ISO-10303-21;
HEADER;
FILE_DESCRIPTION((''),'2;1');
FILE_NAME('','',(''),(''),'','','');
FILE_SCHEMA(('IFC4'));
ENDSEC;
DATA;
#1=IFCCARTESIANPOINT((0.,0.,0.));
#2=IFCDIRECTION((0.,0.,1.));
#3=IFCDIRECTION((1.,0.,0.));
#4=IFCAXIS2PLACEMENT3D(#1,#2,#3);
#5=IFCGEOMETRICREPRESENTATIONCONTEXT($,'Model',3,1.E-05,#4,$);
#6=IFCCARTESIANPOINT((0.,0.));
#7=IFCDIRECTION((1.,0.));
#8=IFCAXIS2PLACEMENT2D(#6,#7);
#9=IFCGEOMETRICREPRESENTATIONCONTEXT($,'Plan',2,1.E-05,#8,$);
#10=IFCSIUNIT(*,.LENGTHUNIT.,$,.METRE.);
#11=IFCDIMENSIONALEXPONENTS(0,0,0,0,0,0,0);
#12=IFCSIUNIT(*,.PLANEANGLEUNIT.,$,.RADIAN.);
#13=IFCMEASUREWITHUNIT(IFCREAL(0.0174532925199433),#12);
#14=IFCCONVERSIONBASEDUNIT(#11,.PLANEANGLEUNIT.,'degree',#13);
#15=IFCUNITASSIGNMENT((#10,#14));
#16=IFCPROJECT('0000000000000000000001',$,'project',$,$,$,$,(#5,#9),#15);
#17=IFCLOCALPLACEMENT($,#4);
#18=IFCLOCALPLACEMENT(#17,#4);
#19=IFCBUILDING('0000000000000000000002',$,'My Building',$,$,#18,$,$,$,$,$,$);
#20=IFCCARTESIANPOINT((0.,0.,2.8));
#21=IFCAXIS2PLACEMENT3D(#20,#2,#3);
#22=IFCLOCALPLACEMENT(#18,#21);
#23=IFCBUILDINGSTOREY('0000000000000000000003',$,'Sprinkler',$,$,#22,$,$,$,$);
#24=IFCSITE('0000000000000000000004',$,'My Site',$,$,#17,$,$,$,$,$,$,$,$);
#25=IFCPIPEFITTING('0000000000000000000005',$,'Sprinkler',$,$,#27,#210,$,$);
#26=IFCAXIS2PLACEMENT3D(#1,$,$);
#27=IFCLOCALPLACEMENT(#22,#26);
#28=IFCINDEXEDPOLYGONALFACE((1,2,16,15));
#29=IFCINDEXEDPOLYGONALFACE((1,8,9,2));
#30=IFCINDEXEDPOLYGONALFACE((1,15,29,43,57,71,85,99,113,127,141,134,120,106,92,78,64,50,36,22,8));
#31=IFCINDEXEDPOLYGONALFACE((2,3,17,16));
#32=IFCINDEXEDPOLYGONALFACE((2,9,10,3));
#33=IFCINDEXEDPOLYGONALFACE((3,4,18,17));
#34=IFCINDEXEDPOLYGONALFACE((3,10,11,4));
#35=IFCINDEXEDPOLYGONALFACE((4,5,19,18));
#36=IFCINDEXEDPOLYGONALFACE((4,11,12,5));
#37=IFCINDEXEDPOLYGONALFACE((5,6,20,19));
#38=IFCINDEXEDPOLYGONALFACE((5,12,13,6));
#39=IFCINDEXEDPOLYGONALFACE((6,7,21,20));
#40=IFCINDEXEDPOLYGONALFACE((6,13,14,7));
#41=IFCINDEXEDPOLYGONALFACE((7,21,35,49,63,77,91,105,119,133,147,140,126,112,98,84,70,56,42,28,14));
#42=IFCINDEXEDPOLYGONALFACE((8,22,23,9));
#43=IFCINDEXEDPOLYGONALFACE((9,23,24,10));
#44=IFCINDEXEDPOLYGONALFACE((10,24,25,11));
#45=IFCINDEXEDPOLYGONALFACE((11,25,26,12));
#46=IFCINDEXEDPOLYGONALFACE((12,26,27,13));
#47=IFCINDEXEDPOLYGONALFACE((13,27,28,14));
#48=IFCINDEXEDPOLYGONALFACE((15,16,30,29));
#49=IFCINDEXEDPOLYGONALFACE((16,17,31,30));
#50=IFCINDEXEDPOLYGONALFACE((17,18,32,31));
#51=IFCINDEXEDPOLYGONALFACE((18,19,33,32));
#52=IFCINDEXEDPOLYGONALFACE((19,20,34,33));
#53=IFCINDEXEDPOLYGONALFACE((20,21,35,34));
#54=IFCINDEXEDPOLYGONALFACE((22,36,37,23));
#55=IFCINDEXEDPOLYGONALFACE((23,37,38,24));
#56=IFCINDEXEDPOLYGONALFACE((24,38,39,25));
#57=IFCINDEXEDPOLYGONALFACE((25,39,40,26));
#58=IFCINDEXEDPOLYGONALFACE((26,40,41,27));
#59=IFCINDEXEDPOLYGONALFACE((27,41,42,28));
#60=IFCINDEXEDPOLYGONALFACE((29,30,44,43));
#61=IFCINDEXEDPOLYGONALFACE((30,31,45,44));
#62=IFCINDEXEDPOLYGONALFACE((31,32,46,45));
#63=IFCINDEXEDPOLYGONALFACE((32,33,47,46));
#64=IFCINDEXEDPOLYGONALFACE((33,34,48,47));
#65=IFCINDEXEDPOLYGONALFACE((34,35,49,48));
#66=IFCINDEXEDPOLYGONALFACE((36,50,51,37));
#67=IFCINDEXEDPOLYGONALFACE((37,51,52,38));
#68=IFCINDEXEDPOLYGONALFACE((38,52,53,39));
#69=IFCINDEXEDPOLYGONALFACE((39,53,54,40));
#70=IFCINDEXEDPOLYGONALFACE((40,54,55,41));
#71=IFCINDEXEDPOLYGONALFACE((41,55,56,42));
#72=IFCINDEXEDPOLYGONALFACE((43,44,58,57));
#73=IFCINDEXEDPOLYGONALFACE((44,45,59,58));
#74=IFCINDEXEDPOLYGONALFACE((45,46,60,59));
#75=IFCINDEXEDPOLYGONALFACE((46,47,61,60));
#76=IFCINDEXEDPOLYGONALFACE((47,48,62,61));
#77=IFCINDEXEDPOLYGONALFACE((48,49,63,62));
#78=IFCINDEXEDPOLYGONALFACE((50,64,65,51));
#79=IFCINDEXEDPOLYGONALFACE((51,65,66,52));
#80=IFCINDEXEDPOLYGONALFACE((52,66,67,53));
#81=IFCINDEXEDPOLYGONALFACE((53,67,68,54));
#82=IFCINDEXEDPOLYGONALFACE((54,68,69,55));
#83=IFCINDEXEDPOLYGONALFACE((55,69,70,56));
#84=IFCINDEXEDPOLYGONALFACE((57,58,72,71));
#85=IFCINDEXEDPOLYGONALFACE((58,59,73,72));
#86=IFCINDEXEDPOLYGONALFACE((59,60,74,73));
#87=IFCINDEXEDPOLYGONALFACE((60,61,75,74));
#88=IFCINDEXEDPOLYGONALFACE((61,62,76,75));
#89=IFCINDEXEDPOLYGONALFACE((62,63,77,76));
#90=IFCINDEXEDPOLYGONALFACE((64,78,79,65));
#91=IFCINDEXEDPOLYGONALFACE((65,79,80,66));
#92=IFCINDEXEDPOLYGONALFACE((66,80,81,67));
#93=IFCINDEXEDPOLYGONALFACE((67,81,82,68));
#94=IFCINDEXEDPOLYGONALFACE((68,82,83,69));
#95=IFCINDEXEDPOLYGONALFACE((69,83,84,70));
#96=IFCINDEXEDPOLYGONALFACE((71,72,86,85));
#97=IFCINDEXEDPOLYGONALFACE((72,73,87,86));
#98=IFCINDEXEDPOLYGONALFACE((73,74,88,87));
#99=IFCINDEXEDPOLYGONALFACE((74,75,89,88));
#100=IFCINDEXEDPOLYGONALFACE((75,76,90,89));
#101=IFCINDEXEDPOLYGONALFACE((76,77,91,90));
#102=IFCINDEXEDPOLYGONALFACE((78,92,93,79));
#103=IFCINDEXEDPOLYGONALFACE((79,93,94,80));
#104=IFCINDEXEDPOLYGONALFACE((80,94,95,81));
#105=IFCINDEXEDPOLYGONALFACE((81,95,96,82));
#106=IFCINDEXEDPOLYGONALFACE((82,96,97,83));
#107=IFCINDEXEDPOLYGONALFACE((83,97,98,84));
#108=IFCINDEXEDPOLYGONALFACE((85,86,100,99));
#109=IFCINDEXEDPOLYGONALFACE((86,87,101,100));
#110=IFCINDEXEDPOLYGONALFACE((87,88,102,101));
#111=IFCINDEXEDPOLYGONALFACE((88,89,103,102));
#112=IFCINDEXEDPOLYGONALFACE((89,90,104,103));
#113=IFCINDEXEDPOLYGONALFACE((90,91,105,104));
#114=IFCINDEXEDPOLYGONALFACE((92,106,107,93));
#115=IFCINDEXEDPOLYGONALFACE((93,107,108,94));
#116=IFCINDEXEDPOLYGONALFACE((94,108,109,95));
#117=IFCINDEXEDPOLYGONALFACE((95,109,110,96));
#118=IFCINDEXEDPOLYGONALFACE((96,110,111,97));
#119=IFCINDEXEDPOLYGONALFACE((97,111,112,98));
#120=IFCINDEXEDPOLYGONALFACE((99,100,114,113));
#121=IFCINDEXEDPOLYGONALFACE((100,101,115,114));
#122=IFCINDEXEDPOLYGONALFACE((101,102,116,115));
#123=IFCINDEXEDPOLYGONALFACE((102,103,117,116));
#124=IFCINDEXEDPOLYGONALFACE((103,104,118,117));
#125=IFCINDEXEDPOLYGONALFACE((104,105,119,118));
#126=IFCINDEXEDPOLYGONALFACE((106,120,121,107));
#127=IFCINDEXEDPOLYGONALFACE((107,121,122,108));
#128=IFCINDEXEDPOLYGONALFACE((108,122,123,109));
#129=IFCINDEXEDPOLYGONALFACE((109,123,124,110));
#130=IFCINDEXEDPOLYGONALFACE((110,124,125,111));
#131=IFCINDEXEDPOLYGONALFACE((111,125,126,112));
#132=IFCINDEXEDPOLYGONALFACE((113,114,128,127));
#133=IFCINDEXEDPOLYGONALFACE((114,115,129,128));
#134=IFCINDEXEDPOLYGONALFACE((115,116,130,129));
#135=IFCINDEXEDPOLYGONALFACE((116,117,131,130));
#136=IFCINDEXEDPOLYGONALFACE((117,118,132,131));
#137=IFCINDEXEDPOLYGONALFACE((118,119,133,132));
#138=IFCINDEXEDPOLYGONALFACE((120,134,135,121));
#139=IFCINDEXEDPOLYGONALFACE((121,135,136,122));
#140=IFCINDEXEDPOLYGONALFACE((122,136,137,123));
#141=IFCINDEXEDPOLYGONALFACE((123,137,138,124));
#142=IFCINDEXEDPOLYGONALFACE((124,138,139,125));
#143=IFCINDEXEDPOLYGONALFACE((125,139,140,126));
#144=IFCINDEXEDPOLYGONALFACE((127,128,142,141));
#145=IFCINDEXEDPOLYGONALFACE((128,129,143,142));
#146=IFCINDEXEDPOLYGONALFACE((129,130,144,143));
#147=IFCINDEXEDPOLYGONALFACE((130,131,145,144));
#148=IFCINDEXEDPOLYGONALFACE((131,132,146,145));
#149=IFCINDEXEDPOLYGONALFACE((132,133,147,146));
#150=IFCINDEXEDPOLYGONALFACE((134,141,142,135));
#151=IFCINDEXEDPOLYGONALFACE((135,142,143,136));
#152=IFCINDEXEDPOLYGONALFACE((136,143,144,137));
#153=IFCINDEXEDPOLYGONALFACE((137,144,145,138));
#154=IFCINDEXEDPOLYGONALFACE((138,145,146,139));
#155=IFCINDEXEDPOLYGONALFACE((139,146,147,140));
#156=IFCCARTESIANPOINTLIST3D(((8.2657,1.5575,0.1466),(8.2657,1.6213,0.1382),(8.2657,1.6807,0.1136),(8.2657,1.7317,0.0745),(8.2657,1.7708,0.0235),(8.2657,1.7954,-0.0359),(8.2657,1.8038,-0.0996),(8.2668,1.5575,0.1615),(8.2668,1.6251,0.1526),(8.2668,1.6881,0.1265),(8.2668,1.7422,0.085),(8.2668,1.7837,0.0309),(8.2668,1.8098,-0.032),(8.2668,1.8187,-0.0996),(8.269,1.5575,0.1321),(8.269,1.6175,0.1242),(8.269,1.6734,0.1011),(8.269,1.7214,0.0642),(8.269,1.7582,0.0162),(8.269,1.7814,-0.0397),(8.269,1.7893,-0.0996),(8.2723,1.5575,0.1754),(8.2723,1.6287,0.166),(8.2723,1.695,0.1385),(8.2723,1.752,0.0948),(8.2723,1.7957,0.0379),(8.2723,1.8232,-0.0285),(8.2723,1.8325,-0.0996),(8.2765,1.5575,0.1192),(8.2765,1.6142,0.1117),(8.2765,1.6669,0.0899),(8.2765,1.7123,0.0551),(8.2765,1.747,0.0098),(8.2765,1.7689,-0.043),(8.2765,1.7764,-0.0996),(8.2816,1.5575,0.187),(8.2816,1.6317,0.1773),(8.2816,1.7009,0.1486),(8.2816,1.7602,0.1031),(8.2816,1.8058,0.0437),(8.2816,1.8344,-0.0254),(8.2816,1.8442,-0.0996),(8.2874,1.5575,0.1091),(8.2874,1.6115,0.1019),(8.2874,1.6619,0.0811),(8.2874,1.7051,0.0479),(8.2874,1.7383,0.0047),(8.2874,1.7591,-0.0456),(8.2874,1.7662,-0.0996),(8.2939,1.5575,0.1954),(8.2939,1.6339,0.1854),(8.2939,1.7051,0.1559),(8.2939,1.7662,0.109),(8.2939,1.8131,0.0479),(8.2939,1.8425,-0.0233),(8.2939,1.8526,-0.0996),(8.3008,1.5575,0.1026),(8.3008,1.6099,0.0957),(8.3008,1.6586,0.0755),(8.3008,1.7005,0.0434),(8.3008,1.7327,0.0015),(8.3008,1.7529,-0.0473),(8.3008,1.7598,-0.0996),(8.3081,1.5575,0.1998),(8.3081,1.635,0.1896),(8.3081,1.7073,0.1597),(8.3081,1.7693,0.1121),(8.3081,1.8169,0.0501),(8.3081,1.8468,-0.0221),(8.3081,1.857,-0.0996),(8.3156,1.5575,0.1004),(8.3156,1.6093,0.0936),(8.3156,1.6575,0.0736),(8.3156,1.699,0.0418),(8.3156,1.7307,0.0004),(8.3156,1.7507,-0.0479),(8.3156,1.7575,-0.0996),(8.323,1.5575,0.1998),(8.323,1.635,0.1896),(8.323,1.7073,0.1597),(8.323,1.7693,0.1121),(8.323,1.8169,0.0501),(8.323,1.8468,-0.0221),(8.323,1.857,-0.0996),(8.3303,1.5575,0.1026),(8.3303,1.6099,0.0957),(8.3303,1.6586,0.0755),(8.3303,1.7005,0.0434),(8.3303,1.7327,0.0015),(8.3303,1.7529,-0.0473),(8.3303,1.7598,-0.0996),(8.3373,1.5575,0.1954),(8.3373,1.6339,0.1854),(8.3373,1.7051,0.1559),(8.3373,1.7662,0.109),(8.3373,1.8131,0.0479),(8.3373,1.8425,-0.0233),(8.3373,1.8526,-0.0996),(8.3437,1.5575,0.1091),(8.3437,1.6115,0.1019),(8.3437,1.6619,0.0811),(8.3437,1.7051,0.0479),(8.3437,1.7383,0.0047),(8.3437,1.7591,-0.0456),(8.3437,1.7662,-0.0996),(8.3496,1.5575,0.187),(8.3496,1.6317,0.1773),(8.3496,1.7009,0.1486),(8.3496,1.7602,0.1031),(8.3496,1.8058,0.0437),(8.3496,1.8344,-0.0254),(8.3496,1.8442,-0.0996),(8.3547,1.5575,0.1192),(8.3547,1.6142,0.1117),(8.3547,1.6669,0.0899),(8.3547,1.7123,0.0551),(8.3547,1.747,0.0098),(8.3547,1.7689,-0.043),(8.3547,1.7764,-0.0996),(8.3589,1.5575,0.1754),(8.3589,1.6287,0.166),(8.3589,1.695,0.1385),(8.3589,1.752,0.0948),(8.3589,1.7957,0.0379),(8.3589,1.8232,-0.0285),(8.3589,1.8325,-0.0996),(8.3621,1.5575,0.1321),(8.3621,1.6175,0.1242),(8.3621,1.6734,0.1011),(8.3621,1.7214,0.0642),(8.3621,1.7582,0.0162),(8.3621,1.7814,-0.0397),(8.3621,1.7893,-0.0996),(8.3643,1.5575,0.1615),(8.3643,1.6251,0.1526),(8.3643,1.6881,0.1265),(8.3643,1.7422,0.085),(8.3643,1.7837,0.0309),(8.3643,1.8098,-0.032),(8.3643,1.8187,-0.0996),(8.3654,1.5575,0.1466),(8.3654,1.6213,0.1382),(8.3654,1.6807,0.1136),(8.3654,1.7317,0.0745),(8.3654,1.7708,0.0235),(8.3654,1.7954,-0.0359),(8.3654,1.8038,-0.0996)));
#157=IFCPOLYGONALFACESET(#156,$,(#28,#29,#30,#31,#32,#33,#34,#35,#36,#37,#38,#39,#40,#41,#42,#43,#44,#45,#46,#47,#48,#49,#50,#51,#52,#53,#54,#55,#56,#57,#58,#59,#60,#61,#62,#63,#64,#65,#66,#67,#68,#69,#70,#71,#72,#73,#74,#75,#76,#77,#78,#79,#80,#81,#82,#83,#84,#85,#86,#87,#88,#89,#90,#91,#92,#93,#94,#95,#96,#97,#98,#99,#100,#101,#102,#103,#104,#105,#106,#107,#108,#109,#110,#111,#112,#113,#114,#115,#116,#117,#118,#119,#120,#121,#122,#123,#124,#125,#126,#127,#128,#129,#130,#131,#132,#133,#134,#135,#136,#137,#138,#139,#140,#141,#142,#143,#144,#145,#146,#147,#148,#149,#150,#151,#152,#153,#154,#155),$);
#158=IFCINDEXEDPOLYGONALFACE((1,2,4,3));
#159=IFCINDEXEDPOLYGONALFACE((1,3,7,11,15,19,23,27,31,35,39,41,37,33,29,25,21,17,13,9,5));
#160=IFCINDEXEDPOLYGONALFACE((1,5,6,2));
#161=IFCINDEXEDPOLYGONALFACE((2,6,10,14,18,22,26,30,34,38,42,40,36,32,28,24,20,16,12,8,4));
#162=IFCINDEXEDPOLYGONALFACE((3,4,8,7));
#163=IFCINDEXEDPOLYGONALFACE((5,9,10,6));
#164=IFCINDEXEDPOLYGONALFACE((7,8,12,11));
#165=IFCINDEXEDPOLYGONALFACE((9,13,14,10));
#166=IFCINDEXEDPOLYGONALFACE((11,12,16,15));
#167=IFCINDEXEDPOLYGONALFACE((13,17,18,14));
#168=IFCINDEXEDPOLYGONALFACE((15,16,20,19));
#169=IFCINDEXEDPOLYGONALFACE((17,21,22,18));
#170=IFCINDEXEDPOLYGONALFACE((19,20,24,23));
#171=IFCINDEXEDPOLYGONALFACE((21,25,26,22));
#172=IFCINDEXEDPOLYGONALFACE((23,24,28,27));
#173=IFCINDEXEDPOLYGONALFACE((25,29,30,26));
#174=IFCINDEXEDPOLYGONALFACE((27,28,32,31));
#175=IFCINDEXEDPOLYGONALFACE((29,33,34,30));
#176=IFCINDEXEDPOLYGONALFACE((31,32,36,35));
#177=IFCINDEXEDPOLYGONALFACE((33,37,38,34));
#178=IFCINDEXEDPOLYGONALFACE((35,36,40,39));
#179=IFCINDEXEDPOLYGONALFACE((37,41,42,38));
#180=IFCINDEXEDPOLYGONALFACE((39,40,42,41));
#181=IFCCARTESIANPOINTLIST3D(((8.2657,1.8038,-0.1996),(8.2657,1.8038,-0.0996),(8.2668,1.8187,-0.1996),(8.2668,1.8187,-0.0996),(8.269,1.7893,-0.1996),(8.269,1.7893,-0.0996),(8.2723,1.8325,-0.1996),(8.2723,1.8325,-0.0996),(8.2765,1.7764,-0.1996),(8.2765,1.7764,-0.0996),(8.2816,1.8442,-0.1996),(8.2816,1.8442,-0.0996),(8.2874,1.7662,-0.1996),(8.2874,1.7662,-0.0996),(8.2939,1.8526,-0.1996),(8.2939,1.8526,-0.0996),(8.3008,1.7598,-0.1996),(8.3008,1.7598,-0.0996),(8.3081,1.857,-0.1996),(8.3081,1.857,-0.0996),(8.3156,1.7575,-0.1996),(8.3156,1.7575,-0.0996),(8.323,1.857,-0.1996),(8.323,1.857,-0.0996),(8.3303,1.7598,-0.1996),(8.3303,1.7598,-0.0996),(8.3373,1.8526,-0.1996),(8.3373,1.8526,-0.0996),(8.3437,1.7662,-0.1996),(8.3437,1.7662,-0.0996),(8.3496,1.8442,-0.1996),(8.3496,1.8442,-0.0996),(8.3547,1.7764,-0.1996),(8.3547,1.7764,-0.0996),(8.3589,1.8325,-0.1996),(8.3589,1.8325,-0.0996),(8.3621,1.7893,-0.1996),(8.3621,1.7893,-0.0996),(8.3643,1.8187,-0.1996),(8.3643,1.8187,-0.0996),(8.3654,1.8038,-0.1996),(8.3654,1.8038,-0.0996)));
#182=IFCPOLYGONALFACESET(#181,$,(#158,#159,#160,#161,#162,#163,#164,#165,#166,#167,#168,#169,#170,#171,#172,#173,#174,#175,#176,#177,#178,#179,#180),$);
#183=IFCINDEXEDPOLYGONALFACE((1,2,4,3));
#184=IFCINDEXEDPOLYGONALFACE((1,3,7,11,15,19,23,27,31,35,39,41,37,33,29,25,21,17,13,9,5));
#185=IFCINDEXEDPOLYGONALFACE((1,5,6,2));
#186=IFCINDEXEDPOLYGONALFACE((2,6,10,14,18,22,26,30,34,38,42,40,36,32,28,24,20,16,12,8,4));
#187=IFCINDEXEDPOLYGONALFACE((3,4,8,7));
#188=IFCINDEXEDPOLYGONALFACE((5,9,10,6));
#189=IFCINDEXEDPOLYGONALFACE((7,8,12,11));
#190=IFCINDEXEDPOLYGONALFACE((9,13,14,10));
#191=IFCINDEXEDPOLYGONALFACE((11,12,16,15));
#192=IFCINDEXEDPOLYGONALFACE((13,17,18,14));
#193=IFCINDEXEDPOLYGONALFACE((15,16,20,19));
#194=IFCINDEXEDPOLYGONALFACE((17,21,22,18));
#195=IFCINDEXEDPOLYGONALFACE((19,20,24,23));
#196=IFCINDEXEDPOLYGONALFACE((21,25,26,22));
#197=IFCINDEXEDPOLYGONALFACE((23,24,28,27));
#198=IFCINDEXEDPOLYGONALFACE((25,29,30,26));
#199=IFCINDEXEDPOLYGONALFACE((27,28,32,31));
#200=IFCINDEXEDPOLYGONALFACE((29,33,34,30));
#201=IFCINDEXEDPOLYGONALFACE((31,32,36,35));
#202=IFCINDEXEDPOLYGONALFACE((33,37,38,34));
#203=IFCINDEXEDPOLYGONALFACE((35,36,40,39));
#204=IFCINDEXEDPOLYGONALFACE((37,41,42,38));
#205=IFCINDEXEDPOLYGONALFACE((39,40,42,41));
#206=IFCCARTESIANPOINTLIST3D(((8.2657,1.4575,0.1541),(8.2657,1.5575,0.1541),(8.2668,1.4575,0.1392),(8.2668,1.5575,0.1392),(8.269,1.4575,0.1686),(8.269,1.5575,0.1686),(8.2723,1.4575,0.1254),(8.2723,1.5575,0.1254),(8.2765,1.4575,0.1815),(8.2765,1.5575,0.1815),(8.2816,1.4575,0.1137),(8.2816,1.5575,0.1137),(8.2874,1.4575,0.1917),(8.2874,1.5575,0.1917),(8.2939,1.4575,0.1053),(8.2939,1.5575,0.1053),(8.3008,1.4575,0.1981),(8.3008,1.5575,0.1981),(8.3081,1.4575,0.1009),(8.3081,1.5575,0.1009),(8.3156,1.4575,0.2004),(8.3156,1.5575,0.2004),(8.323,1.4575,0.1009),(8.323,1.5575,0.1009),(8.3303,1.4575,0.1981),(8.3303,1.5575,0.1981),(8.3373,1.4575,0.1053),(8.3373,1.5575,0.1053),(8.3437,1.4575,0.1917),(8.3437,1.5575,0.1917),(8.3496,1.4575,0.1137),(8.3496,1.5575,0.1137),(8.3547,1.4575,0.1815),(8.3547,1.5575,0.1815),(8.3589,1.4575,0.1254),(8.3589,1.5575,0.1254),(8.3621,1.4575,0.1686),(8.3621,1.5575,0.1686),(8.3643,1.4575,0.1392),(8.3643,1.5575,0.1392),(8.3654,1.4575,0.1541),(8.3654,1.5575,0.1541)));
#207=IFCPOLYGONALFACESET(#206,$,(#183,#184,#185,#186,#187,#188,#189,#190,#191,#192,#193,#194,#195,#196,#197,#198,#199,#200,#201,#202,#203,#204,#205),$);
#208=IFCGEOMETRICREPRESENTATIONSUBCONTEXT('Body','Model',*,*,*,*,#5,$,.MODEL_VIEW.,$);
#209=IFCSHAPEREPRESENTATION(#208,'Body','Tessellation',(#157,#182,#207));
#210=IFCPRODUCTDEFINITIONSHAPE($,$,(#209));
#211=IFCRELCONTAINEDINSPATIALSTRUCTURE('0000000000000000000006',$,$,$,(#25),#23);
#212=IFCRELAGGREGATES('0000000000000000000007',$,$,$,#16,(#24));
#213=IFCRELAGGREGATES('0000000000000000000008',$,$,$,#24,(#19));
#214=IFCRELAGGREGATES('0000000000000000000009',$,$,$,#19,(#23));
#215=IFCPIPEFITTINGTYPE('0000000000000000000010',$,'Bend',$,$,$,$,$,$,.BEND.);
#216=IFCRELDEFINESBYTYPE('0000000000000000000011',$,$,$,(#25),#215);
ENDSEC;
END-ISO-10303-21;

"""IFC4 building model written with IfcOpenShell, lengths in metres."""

from ifc_helpers import new_model, entity, si_unit, converted_unit, frame, origin_with_axes, origin_2d_with_axis, place, context, subcontext, project, spatial, circle, extrude, source, transform, mapped, type_object, type_shapes, element, save


model = new_model("IFC4")

# Units and contexts
model_context = context("Model", 3, precision=1e-05, world=origin_with_axes())
plan_context = context("Plan", 2, precision=1e-05, world=origin_2d_with_axis())
body_context = subcontext(model_context, "Body", "Model", "MODEL_VIEW")
ifc_project = project(units=[si_unit("LENGTHUNIT", "METRE"), converted_unit("PLANEANGLEUNIT", "degree", entity("IfcReal", 0.0174532925199433), si_unit("PLANEANGLEUNIT", "RADIAN"), dimensions=[0, 0, 0, 0, 0, 0, 0])], contexts=[model_context, plan_context])

# Site, building, storey
site_placement = place(None, origin_with_axes())
site = spatial("IfcSite", under=ifc_project, at=site_placement, Name="My Site")
building_placement = place(site_placement, origin_with_axes())
building = spatial("IfcBuilding", under=site, at=building_placement, Name="My Building")
storey_placement = place(building_placement, frame((0.0, 0.0, 2.8), z_axis=(0.0, 0.0, 1.0), x_axis=(1.0, 0.0, 0.0)))
storey = spatial("IfcBuildingStorey", under=building, at=storey_placement, Name="Sprinkler")

# Pipe fitting
pipe_fitting_type_1 = type_object("IfcPipeFittingType", Name="Bend", PredefinedType="BEND")
shared_shape = source(origin_with_axes(), body_context, "Body", "SolidModel", [
    entity("IfcSweptDiskSolid", entity("IfcIndexedPolyCurve", entity("IfcCartesianPointList3D", [[0.0, 0.0, 0.1], [0.0732, 0.0, 0.2768], [0.25, 0.0, 0.35]]), [entity("IfcArcIndex", [1, 2, 3])]), 0.05),
    extrude(circle(Radius=0.05), origin_with_axes(), (0.0, 0.0, 1.0), 0.1),
    extrude(circle(Radius=0.05), frame((0.25, 0.0, 0.35), z_axis=(1.0, 0.0, 0.000001), x_axis=(-0.000001, 0.0, 1.0)), (0.0, 0.0, 1.0), 0.1),
])
type_shapes(pipe_fitting_type_1, [shared_shape])
for number, where, z_axis, x_axis, name in (
    (1, (8.3156, 1.8075, -0.1996), (0.0, -0.000008, 1.0), (0.0, -1.0, -0.000008), "Sprinkler"),
):
    element("IfcPipeFitting", number, at=place(storey_placement, frame(where, z_axis=z_axis, x_axis=x_axis)), inside=storey, type_object=pipe_fitting_type_1, Name=name, context=body_context, shape_type="MappedRepresentation", body=[
        mapped(shared_shape, transform((0.0, 0.0, 0.0), x_axis=(1.0, 0.0, 0.0), y_axis=(0.0, 1.0, 0.0), z_axis=(0.0, 0.0, 1.0), scale=1.0)),
    ])

save(model, "model.ifc")
